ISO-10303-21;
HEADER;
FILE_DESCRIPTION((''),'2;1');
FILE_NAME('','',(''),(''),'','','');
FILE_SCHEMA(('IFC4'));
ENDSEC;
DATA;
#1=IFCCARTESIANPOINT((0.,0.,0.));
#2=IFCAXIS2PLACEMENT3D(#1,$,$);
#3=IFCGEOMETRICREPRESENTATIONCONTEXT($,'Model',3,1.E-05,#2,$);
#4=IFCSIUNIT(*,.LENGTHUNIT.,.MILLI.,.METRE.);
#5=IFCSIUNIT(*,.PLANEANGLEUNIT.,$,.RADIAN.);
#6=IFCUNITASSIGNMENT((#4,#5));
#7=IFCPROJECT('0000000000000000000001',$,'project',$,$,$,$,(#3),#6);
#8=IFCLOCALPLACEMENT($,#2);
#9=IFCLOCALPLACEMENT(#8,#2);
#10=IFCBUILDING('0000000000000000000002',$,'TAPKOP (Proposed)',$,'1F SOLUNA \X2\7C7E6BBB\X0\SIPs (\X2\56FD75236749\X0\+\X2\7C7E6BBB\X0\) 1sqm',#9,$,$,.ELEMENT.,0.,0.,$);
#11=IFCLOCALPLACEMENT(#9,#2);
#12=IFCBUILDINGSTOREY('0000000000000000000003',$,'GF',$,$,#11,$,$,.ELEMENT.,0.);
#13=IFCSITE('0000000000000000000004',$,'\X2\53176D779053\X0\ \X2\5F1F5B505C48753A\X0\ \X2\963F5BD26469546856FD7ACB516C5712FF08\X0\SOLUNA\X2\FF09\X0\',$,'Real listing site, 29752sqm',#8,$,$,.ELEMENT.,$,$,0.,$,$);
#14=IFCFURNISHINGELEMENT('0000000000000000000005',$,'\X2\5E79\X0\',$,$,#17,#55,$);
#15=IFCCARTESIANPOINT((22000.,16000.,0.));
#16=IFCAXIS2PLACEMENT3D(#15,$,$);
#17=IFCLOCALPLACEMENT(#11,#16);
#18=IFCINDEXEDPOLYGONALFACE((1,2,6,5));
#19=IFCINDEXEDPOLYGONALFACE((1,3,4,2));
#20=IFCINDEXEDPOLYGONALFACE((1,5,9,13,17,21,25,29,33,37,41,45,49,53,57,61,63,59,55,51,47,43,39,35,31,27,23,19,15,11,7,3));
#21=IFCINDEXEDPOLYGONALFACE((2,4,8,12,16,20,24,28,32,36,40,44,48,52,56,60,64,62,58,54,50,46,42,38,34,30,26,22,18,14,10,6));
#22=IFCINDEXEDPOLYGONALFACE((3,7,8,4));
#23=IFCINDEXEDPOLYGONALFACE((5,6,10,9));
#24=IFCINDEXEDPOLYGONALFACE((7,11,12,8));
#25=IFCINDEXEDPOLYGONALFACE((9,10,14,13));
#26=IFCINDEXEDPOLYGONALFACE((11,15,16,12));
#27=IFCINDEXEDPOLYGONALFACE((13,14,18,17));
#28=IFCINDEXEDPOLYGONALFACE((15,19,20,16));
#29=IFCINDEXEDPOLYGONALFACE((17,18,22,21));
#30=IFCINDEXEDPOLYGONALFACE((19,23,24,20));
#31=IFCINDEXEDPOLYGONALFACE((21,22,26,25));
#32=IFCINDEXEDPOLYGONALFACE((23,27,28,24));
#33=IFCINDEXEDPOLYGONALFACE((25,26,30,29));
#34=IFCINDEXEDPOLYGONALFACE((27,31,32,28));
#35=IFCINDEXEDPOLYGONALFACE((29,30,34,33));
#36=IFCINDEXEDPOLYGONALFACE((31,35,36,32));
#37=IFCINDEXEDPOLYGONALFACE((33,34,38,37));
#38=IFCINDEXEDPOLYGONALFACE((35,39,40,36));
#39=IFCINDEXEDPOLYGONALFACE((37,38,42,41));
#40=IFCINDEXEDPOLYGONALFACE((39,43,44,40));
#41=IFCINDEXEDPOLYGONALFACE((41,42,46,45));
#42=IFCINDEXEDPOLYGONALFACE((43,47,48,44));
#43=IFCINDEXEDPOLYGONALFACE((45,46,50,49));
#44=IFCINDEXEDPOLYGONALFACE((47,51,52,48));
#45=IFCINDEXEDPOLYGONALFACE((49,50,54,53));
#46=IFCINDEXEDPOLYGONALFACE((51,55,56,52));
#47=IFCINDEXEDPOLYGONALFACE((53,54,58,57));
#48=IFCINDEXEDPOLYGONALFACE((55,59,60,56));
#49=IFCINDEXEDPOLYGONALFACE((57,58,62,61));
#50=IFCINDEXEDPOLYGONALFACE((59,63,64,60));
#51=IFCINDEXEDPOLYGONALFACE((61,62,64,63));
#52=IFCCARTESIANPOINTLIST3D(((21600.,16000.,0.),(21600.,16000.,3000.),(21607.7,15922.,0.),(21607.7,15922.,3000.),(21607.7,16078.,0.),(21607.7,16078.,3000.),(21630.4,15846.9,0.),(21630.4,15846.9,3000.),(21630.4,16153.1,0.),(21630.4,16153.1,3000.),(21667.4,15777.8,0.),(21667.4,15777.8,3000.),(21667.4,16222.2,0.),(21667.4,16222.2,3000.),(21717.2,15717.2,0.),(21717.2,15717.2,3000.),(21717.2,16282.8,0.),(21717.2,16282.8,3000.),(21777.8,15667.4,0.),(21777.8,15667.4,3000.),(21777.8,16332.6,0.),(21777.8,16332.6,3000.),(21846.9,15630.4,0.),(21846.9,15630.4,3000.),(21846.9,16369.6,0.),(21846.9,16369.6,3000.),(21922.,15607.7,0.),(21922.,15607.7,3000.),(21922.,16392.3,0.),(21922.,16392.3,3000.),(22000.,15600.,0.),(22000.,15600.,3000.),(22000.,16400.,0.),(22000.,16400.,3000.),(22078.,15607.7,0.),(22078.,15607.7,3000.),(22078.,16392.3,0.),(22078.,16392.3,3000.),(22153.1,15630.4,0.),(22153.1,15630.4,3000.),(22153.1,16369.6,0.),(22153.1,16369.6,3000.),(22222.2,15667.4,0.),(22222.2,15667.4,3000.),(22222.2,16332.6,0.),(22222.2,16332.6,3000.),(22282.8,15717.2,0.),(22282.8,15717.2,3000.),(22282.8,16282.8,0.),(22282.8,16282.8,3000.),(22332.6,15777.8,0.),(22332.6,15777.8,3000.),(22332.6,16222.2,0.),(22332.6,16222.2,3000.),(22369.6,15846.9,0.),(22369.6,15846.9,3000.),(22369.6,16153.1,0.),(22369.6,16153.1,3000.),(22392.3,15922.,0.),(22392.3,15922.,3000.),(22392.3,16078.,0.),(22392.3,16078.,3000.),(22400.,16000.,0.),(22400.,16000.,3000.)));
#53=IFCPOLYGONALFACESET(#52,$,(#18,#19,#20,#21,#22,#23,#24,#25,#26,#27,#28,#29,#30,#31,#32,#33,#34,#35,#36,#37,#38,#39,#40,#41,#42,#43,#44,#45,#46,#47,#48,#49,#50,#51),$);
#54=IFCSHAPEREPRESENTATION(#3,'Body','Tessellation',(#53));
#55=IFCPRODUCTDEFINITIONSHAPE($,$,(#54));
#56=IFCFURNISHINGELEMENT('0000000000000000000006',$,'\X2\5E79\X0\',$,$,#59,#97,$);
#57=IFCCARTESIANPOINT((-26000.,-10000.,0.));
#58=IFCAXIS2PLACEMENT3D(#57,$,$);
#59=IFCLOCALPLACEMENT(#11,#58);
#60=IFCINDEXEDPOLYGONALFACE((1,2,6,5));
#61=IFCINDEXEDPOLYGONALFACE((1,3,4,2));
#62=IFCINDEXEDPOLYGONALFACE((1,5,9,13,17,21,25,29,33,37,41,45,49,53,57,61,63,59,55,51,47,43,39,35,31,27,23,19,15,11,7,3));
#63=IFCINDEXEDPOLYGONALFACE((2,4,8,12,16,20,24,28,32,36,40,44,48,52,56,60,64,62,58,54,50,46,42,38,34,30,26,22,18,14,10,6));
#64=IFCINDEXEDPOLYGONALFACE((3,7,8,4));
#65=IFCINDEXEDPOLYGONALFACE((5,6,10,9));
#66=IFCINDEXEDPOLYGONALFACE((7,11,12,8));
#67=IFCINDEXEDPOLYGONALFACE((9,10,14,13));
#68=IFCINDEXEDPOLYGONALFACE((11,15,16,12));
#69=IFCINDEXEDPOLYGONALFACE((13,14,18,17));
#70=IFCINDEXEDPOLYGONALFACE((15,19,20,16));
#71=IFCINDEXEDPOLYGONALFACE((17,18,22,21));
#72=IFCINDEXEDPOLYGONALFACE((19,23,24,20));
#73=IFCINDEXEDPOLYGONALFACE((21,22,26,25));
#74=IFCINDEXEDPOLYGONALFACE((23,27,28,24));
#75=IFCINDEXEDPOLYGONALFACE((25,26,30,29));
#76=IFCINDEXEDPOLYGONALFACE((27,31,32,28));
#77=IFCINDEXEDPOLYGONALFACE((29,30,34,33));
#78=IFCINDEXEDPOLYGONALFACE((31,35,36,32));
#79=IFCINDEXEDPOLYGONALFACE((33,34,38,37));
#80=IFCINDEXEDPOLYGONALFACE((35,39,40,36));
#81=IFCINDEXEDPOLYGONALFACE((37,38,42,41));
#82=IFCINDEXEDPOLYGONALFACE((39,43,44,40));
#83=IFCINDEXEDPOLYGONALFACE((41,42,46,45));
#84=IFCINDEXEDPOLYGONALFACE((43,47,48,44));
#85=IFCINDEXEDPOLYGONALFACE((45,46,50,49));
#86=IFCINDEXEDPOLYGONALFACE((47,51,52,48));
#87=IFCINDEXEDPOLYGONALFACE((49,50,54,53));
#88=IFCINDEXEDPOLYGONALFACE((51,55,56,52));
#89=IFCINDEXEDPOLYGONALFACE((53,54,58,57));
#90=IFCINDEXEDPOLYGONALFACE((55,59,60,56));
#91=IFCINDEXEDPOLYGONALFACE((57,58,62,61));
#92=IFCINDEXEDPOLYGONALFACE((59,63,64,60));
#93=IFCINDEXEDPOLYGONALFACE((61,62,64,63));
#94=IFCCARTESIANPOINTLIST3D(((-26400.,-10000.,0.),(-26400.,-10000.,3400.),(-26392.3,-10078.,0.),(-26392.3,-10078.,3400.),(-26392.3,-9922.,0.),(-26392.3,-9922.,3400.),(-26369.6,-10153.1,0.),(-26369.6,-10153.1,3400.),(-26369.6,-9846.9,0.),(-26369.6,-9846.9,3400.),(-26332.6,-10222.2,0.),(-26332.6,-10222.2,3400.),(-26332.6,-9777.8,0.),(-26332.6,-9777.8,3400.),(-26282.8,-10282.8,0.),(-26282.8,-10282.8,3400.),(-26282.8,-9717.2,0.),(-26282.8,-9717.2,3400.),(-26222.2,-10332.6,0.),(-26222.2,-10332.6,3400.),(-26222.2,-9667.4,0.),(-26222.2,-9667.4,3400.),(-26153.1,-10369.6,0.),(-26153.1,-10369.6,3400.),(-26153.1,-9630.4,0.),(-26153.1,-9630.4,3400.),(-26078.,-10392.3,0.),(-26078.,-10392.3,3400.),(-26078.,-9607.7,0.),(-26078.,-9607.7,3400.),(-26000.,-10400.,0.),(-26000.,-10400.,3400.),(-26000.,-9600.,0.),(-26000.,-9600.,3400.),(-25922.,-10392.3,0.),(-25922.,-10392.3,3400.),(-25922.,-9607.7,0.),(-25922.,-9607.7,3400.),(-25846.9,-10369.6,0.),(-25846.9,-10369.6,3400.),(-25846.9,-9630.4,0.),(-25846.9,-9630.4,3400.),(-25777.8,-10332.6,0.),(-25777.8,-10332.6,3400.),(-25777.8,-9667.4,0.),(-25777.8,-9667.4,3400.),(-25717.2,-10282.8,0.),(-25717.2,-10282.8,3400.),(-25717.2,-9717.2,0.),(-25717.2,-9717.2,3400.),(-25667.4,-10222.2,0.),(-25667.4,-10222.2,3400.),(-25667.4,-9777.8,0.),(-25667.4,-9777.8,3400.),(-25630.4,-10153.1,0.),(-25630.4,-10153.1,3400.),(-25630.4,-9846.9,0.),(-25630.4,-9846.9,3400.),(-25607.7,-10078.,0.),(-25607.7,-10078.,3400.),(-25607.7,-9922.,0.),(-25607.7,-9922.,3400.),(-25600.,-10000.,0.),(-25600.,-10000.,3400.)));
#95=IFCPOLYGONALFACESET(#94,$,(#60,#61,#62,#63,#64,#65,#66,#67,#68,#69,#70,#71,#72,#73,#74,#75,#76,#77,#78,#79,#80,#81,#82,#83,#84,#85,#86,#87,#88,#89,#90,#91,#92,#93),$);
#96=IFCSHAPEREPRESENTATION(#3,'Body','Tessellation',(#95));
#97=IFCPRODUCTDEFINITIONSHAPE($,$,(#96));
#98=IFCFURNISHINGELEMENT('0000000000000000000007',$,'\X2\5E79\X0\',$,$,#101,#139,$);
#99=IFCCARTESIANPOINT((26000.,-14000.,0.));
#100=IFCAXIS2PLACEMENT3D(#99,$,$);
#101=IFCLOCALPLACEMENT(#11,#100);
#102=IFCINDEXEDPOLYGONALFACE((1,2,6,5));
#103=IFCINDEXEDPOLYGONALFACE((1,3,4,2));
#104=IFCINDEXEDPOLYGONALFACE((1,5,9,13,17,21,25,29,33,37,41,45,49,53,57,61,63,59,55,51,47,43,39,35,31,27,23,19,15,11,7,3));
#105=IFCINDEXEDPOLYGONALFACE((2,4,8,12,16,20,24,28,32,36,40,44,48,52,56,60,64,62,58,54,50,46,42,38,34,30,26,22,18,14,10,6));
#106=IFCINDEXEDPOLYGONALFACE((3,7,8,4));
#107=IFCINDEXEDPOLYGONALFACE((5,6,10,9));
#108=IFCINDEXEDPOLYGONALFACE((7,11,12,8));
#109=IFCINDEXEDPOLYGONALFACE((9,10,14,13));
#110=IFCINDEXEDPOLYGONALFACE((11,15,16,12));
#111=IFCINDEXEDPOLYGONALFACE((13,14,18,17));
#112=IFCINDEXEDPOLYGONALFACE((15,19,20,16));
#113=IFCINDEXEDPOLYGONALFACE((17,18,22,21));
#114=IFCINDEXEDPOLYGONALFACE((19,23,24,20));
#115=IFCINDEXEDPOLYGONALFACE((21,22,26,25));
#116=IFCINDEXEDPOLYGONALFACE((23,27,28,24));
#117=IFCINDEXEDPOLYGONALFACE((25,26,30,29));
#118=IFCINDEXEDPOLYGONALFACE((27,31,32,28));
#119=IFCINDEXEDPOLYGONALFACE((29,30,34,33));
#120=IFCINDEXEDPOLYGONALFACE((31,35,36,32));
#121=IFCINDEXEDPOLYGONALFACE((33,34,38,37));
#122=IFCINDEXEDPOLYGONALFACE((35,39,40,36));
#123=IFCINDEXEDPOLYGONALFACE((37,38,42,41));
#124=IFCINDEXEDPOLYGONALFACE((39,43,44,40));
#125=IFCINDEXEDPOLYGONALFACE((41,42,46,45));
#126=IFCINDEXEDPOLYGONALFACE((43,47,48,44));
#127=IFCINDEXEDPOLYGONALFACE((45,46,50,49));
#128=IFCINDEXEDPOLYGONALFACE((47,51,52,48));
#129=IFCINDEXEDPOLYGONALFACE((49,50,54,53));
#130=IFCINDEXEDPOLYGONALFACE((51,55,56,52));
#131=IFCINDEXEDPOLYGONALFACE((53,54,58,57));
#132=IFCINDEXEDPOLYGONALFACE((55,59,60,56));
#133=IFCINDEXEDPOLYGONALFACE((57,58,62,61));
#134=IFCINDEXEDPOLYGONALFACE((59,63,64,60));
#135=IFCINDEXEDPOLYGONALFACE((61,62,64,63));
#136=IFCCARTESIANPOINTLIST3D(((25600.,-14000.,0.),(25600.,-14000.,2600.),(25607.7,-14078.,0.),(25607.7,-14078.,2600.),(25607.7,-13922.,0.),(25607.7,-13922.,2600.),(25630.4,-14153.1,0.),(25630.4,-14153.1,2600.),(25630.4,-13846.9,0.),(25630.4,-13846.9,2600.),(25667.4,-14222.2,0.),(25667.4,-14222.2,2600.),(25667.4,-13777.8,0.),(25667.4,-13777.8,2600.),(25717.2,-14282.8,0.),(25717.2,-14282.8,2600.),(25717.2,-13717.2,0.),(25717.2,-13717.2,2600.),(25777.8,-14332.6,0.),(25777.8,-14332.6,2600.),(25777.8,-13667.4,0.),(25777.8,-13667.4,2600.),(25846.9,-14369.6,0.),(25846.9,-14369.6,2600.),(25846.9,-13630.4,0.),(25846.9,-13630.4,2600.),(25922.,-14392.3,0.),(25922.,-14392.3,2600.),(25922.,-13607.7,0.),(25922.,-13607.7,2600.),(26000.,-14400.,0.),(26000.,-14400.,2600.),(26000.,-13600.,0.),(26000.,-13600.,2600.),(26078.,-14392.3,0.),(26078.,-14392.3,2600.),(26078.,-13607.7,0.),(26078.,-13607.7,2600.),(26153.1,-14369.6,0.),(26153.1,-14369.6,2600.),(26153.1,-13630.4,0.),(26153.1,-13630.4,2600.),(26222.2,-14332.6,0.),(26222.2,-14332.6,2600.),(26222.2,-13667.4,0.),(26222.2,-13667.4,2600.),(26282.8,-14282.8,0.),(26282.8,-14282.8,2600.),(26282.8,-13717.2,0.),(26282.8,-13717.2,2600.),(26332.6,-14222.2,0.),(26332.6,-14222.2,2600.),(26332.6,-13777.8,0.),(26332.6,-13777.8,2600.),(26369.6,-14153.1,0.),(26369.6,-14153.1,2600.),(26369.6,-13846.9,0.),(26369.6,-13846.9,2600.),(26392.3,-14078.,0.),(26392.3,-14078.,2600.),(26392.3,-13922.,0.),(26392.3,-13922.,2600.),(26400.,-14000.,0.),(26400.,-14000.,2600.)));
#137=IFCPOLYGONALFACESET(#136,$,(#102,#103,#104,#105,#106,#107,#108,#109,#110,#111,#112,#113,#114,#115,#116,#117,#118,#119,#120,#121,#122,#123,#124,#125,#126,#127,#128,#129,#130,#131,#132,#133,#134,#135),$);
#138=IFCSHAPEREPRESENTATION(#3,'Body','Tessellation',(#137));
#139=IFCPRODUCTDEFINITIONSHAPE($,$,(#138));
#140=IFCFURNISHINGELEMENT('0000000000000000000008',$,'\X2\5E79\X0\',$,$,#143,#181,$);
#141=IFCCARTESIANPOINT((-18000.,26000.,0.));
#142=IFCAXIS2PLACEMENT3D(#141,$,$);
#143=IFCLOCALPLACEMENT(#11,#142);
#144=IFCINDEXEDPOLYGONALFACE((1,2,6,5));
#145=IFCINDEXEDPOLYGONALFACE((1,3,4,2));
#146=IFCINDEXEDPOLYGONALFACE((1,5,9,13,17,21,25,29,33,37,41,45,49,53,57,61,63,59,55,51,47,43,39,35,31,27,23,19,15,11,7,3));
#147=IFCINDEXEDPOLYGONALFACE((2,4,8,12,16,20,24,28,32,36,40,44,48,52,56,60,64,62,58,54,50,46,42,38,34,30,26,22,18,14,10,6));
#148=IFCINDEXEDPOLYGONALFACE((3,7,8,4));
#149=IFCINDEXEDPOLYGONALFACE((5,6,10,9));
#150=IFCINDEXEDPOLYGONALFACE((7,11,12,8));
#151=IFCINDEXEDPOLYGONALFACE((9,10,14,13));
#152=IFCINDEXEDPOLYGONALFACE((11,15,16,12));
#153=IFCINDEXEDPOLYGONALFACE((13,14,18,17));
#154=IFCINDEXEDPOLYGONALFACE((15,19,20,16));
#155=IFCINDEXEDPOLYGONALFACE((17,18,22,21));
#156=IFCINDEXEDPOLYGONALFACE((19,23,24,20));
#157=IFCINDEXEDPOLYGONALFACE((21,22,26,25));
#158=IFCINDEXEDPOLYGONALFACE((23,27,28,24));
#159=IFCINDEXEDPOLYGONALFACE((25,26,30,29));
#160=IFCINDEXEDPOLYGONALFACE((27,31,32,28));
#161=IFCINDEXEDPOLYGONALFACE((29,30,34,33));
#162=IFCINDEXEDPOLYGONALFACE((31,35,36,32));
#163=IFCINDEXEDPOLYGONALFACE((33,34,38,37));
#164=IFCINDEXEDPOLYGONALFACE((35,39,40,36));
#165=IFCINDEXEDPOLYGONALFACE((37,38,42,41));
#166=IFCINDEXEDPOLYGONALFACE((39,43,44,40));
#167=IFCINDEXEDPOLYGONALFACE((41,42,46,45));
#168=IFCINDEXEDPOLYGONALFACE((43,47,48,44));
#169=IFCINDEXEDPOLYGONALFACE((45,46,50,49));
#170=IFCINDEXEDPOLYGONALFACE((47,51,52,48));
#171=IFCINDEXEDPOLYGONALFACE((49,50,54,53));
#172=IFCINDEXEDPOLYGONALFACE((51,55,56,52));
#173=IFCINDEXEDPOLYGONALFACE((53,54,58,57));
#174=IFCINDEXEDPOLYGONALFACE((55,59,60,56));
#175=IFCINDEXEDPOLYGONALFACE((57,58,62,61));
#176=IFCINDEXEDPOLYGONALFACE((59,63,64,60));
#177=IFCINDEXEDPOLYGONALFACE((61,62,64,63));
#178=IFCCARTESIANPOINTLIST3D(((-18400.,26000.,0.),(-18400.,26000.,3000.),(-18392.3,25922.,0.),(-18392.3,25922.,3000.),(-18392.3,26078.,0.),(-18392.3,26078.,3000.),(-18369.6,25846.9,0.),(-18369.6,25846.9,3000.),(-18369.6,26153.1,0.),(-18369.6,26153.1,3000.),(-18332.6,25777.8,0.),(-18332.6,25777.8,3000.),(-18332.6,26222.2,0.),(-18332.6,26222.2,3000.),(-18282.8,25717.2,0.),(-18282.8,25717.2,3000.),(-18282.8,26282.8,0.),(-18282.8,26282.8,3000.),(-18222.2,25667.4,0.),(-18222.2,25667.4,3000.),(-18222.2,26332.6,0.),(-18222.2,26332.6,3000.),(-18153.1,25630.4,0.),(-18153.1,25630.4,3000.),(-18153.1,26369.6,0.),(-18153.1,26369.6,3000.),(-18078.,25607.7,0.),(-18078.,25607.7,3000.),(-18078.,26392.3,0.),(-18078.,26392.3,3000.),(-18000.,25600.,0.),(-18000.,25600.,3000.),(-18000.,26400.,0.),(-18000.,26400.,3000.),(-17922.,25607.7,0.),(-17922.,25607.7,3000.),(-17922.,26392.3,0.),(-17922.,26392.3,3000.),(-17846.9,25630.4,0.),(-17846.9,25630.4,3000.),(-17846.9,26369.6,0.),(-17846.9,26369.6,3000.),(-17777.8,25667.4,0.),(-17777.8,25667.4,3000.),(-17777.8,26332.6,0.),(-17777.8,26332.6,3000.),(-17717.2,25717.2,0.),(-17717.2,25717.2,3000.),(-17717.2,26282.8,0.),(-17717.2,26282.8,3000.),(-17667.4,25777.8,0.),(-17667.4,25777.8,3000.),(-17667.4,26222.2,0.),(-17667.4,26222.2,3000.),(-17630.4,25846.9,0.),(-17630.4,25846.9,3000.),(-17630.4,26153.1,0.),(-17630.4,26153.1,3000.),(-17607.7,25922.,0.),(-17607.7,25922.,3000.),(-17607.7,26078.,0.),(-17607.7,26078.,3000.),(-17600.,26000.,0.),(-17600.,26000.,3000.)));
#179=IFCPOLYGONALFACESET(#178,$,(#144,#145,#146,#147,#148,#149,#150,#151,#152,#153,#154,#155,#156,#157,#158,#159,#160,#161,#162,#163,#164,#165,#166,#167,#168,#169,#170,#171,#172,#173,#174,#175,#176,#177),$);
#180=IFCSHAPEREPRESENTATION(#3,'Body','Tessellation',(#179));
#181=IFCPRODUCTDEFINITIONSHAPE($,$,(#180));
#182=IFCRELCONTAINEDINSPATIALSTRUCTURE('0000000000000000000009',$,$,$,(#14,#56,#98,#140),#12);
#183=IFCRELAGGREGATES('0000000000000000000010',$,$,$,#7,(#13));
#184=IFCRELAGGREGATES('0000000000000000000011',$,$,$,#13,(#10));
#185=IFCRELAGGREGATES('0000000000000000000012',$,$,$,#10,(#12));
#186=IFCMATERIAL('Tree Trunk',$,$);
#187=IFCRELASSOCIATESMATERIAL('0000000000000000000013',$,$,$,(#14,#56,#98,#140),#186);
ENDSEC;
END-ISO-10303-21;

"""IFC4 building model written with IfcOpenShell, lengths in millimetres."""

from ifc_helpers import new_model, si_unit, frame, origin, origin_2d, place, context, project, spatial, circle, extrude, material, element, save


model = new_model("IFC4")

# Units and contexts
model_context = context("Model", 3, precision=1e-05, world=origin())
ifc_project = project(units=[si_unit("LENGTHUNIT", "METRE", prefix="MILLI"), si_unit("PLANEANGLEUNIT", "RADIAN")], contexts=[model_context])

# Site, building, storey
site_placement = place(None, origin())
site = spatial("IfcSite", under=ifc_project, at=site_placement, Name="北海道 弟子屈町 阿寒摩周国立公園（SOLUNA）", ObjectType="Real listing site, 29752sqm", CompositionType="ELEMENT", RefElevation=0.0)
building_placement = place(site_placement, origin())
building = spatial("IfcBuilding", under=site, at=building_placement, Name="TAPKOP (Proposed)", ObjectType="1F SOLUNA 籾殻SIPs (国産杉+籾殻) 1sqm", CompositionType="ELEMENT", ElevationOfRefHeight=0.0, ElevationOfTerrain=0.0)
storey_placement = place(building_placement, origin())
storey = spatial("IfcBuildingStorey", under=building, at=storey_placement, Name="GF", CompositionType="ELEMENT", Elevation=0.0)

# Furnishing elements
ifc_material_1 = material(Name="Tree Trunk")
furnishing_1_placement = place(storey_placement, frame((22000.0, 16000.0, 0.0)))
element("IfcFurnishingElement", 1, at=furnishing_1_placement, inside=storey, material=ifc_material_1, Name="幹", context=model_context, shape_type="SweptSolid", body=[
    extrude(circle(Radius=400.0, at=origin_2d()), frame((22000.0, 16000.0, 0.0)), (0.0, 0.0, 1.0), 3000.0),
])
furnishing_2_placement = place(storey_placement, frame((-26000.0, -10000.0, 0.0)))
element("IfcFurnishingElement", 2, at=furnishing_2_placement, inside=storey, material=ifc_material_1, Name="幹", context=model_context, shape_type="SweptSolid", body=[
    extrude(circle(Radius=400.0, at=origin_2d()), frame((-26000.0, -10000.0, 0.0)), (0.0, 0.0, 1.0), 3400.0),
])
furnishing_3_placement = place(storey_placement, frame((26000.0, -14000.0, 0.0)))
element("IfcFurnishingElement", 3, at=furnishing_3_placement, inside=storey, material=ifc_material_1, Name="幹", context=model_context, shape_type="SweptSolid", body=[
    extrude(circle(Radius=400.0, at=origin_2d()), frame((26000.0, -14000.0, 0.0)), (0.0, 0.0, 1.0), 2600.0),
])
furnishing_4_placement = place(storey_placement, frame((-18000.0, 26000.0, 0.0)))
element("IfcFurnishingElement", 4, at=furnishing_4_placement, inside=storey, material=ifc_material_1, Name="幹", context=model_context, shape_type="SweptSolid", body=[
    extrude(circle(Radius=400.0, at=origin_2d()), frame((-18000.0, 26000.0, 0.0)), (0.0, 0.0, 1.0), 3000.0),
])

save(model, "model.ifc")
